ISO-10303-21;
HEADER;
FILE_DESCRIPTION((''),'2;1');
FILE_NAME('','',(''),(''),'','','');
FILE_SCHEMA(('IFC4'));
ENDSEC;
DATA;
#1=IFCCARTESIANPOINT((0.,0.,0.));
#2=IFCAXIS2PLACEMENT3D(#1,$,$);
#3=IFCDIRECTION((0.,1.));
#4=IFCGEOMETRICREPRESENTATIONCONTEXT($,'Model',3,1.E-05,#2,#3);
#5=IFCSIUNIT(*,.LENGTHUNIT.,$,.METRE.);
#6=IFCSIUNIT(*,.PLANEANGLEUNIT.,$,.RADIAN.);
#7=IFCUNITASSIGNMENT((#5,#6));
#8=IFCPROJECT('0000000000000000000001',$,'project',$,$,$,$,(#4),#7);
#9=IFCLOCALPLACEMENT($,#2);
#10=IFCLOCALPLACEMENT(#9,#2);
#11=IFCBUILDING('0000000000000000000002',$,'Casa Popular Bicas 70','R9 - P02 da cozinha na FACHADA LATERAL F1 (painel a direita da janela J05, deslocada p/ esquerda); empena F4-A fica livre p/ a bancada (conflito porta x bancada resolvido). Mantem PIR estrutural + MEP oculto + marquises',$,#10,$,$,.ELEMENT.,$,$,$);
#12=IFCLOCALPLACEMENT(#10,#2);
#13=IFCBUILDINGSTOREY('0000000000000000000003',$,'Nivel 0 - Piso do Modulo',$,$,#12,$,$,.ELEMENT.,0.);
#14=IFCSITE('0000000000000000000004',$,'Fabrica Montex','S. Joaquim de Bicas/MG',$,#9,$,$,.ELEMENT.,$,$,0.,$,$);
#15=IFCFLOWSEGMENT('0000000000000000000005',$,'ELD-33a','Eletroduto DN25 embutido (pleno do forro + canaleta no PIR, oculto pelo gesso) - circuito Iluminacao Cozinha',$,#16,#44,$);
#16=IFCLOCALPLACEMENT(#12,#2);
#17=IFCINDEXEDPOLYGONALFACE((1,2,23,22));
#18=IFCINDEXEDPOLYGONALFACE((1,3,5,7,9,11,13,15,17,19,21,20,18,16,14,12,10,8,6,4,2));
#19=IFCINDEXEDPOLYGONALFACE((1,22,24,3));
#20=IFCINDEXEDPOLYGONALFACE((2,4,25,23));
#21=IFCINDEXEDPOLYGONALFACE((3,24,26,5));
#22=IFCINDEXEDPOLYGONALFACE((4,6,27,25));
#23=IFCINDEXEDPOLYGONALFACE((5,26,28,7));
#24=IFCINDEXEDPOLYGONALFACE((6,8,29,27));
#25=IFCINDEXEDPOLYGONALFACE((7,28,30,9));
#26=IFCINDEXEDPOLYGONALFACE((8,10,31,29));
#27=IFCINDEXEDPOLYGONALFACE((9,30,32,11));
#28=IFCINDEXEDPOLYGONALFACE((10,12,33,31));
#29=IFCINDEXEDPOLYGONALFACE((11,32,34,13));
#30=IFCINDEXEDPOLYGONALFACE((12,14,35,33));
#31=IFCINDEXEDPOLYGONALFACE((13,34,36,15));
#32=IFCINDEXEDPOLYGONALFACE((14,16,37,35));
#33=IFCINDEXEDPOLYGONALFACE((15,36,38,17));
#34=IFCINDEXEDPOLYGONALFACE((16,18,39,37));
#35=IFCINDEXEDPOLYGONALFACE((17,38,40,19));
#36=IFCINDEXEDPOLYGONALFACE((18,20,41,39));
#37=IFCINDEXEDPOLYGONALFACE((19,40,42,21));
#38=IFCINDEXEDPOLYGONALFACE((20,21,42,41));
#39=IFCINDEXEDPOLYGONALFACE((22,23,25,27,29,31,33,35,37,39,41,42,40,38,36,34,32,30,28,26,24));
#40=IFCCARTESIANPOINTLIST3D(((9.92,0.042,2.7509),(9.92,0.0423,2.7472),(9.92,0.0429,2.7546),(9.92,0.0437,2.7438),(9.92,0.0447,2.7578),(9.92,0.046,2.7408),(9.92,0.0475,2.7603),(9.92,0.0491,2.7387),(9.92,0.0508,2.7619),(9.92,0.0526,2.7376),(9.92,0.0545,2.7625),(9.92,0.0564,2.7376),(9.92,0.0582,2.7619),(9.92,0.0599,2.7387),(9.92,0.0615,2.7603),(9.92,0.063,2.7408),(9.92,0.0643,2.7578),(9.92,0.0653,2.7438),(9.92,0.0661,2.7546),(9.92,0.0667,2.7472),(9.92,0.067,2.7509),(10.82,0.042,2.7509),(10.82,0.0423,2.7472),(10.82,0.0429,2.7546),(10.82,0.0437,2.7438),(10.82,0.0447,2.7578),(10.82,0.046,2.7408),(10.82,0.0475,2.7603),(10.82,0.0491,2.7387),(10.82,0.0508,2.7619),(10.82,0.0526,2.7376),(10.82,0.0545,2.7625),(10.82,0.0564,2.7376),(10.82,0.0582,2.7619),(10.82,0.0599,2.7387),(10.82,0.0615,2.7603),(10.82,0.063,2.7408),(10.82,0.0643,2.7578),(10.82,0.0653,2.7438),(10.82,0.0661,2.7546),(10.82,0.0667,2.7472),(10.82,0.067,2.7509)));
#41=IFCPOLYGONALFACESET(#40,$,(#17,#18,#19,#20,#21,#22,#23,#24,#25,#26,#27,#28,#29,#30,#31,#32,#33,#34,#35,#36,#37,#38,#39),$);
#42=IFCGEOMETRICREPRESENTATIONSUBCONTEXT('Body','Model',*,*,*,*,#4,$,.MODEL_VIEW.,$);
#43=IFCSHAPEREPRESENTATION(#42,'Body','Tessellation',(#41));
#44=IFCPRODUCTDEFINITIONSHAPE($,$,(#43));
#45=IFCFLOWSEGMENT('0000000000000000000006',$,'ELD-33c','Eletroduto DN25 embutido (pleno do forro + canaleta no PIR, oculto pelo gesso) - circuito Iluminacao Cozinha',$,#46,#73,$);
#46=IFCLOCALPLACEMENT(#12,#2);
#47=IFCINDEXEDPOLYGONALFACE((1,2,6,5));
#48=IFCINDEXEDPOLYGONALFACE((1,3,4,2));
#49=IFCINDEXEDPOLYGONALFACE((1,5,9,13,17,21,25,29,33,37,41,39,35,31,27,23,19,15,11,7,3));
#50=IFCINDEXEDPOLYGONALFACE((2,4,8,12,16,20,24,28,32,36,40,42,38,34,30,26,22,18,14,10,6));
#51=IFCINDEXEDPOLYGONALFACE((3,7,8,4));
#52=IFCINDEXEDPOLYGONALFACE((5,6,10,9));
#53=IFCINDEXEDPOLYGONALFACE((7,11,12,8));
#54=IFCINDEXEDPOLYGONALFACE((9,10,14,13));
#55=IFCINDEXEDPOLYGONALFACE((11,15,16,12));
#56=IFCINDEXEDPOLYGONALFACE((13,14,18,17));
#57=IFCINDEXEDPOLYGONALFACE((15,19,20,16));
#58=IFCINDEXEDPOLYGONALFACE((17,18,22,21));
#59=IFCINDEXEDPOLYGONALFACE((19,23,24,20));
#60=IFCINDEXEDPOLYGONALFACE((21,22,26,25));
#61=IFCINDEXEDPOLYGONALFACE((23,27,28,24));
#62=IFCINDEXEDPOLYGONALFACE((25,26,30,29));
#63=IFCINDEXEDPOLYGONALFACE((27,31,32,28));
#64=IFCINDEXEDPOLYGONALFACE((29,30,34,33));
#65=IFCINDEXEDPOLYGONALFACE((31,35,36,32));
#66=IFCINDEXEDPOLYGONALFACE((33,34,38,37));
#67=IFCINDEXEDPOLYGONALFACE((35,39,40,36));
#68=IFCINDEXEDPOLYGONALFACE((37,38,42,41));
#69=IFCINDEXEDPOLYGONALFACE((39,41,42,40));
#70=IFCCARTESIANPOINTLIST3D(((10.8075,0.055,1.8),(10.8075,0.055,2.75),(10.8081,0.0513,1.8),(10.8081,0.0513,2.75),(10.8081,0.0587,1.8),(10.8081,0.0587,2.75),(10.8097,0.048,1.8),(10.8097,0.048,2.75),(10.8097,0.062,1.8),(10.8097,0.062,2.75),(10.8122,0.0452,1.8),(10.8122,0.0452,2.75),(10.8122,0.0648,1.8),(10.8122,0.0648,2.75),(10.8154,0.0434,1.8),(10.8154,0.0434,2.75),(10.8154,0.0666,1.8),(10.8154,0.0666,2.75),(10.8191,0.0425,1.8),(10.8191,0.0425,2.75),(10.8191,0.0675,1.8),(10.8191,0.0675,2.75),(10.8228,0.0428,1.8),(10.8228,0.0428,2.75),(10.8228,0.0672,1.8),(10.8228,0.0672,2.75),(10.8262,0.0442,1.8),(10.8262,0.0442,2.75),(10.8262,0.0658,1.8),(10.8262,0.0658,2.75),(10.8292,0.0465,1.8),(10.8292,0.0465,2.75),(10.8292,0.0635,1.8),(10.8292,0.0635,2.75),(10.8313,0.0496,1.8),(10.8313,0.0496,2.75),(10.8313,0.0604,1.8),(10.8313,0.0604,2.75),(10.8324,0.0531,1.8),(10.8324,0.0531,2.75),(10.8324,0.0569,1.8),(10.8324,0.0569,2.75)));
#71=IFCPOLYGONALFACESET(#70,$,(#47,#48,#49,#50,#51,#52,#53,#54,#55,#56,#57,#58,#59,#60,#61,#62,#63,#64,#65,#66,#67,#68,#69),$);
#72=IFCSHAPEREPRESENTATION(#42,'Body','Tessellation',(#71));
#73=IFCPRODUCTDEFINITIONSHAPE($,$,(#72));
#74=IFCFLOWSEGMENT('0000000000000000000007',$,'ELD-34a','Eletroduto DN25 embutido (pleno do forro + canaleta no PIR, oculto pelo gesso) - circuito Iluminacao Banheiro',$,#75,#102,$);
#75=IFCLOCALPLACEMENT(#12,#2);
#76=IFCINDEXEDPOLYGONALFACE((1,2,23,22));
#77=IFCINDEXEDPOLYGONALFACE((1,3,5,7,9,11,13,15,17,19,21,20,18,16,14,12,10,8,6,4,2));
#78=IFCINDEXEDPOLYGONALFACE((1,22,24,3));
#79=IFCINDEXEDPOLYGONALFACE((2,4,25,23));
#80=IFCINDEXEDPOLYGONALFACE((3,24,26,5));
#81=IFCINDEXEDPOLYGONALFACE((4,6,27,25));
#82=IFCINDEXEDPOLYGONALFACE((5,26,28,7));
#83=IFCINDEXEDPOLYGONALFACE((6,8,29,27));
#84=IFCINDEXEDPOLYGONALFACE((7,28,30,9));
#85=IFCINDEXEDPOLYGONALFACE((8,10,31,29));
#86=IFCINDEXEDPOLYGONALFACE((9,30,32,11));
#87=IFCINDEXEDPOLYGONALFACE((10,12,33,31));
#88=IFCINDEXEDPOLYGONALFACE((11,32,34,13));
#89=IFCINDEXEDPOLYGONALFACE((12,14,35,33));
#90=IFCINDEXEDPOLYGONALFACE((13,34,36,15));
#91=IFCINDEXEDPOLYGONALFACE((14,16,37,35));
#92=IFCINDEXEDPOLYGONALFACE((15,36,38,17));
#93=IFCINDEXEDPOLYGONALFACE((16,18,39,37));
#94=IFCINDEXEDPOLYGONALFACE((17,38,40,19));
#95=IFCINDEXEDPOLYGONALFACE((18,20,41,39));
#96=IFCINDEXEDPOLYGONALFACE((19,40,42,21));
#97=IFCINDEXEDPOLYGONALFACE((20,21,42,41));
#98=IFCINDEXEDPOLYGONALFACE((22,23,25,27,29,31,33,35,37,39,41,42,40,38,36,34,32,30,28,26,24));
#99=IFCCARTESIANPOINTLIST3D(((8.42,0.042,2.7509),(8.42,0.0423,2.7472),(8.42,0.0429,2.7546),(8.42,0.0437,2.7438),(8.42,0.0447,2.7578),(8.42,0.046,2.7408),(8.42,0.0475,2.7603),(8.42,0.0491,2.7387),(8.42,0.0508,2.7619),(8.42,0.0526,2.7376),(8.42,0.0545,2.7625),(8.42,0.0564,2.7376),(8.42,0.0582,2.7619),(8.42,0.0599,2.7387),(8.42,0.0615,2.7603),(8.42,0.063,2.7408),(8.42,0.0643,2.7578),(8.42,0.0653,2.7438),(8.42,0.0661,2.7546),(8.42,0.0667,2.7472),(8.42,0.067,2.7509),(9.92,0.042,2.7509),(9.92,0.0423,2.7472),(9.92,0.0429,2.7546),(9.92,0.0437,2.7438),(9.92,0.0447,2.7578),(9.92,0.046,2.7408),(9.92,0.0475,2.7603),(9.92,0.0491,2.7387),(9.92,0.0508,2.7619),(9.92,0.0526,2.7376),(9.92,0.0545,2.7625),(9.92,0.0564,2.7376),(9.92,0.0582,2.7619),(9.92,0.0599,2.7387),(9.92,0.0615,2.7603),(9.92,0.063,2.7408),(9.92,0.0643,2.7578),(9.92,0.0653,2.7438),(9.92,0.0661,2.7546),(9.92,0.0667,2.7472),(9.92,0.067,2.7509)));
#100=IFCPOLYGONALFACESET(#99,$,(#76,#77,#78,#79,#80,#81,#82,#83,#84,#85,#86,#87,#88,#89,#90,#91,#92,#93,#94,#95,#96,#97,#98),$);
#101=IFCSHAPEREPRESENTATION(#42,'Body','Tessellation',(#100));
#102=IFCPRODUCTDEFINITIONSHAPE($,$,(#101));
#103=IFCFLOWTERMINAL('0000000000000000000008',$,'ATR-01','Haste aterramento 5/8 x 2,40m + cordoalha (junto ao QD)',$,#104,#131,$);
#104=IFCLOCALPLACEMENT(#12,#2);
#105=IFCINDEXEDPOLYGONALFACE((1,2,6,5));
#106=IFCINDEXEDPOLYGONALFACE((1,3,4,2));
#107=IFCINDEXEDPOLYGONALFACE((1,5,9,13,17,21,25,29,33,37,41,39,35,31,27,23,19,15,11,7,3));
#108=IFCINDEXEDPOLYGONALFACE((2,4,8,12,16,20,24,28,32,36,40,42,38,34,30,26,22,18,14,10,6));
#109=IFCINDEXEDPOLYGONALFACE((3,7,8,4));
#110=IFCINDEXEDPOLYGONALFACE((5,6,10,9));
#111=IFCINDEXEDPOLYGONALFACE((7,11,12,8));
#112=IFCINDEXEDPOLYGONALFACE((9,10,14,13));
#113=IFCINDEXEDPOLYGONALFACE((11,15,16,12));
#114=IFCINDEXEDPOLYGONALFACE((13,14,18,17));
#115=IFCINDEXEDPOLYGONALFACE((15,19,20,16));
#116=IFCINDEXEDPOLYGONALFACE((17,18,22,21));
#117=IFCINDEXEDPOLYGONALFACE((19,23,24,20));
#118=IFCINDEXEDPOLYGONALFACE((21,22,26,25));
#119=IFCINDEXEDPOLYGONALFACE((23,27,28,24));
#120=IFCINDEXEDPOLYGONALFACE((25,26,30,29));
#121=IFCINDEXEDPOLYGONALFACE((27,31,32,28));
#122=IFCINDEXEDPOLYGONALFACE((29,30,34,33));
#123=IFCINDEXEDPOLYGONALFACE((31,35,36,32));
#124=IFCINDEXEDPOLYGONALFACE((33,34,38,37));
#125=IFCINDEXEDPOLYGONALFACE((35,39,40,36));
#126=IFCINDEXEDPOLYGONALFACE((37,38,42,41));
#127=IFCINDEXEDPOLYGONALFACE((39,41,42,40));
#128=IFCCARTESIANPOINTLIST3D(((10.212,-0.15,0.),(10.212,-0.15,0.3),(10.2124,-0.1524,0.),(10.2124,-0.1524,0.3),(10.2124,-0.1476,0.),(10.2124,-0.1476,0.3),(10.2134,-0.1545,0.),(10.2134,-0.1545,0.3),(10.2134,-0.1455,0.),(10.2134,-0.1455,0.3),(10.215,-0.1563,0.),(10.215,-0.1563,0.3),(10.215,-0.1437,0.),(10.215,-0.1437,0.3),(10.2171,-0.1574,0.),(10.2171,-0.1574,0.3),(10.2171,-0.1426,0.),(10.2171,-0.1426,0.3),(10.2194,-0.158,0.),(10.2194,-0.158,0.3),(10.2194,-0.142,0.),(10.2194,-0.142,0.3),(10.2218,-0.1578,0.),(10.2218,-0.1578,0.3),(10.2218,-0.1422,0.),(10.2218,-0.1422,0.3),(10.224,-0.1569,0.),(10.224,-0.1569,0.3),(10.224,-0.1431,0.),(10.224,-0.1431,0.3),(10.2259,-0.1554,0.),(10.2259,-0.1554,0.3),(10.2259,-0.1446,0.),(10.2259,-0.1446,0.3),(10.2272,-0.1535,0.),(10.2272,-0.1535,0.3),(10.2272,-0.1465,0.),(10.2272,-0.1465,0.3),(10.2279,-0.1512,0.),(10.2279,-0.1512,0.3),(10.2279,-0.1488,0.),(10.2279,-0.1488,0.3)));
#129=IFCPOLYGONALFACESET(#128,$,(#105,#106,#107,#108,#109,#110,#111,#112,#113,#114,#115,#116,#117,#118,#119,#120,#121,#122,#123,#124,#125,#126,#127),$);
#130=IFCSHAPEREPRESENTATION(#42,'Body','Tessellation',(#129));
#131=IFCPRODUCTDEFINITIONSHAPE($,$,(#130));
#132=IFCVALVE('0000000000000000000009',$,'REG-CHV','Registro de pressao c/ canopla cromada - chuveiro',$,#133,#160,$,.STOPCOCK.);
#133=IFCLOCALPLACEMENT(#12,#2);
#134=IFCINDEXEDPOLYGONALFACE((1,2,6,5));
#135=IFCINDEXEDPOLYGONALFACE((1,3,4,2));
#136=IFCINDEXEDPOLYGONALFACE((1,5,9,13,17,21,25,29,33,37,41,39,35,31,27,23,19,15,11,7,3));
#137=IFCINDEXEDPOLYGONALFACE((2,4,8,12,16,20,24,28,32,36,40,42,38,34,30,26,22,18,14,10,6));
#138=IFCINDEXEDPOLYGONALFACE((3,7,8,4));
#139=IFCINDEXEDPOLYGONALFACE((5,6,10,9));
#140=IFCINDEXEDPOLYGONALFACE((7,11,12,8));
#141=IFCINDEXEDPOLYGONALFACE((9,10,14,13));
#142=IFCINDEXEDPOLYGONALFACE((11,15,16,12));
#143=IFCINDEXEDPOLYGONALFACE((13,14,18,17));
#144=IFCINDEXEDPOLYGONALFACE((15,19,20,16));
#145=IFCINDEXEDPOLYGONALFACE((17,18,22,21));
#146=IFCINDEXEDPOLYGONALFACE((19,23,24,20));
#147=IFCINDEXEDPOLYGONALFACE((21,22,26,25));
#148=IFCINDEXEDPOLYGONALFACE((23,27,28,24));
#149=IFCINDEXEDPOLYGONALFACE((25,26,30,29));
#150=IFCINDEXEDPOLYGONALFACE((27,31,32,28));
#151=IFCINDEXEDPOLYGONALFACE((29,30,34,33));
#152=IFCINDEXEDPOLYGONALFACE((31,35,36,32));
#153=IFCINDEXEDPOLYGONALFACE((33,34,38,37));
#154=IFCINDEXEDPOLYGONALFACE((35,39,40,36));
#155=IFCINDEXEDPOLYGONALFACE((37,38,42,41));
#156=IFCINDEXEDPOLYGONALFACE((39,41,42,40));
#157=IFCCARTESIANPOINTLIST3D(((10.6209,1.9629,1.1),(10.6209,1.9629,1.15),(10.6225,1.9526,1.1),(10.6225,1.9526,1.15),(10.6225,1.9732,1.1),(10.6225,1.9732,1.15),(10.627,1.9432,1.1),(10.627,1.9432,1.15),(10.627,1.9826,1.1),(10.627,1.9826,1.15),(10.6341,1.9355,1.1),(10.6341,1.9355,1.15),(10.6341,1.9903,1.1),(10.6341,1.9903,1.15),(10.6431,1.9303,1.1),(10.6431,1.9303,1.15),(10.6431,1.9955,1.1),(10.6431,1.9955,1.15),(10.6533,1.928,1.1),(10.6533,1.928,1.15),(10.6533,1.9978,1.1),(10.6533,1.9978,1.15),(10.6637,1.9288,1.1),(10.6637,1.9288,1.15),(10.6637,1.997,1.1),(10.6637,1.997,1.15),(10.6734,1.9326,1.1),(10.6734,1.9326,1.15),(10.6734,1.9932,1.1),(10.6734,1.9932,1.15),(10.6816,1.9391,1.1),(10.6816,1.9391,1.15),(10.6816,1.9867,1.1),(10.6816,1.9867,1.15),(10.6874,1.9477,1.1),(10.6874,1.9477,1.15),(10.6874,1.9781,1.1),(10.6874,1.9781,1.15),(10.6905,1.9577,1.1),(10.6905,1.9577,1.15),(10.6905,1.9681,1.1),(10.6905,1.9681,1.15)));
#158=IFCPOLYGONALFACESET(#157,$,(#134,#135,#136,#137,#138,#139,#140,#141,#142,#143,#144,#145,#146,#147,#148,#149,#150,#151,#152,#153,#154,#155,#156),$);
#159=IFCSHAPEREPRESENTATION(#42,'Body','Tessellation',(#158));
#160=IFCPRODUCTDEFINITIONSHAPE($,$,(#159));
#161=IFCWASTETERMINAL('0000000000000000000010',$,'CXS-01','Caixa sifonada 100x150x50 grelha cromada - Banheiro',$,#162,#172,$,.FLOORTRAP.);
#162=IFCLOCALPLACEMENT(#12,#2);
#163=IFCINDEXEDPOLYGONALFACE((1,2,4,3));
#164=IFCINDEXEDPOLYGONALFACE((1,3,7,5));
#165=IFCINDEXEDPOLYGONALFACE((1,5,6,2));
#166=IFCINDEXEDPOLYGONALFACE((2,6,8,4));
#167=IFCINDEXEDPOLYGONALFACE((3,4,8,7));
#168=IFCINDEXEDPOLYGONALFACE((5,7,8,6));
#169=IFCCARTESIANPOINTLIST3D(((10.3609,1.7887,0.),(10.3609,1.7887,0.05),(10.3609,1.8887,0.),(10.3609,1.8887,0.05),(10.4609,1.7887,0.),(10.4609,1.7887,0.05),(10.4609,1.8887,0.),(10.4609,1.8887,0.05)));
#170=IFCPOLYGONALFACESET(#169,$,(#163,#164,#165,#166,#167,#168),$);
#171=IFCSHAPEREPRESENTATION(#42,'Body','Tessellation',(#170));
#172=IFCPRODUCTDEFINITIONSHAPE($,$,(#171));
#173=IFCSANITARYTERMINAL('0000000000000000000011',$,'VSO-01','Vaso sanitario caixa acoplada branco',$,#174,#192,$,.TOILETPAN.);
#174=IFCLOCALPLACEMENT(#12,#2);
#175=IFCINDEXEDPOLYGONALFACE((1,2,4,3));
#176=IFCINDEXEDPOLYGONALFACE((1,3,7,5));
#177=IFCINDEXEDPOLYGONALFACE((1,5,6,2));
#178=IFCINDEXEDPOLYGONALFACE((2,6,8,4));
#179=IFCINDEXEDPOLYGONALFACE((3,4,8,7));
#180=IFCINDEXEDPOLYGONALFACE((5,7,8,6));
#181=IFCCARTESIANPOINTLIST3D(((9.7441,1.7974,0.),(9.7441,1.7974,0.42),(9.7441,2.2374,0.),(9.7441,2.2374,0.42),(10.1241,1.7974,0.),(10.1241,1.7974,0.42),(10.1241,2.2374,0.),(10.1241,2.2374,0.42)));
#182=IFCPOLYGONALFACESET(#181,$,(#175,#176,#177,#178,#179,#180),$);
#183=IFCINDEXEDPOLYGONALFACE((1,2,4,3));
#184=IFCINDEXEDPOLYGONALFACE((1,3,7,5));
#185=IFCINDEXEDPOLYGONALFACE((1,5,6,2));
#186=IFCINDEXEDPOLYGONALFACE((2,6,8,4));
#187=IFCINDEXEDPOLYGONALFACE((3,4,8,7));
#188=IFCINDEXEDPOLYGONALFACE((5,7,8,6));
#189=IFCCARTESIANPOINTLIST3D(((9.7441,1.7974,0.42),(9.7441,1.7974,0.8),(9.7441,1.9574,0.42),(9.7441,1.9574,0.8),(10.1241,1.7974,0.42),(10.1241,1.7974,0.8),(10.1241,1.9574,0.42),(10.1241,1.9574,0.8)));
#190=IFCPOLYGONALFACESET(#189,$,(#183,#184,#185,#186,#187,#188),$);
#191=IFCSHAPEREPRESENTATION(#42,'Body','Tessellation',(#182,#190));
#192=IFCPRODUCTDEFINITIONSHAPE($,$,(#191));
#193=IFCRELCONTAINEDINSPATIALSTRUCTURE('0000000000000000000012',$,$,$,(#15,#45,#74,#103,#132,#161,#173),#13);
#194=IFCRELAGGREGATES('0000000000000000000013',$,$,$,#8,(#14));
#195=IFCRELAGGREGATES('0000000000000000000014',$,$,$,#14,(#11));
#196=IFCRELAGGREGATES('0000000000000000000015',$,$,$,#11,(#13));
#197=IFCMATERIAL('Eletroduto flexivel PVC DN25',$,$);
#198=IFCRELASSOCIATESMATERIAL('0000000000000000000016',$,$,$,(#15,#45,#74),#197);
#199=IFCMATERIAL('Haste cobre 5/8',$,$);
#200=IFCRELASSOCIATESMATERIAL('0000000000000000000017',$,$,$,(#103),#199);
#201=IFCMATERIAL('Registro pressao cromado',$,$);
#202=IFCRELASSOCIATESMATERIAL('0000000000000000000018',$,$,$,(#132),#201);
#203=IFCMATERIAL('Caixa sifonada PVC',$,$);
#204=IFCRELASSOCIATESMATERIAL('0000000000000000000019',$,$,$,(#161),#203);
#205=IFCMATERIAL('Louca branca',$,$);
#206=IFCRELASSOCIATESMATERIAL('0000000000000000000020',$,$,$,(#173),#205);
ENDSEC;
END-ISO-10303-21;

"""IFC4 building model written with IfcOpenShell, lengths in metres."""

from ifc_helpers import new_model, si_unit, direction, frame, frame_2d, origin, origin_2d, place, context, subcontext, project, spatial, rectangle, circle, extrude, material, element, save


model = new_model("IFC4")

# Units and contexts
model_context = context("Model", 3, precision=1e-05, world=origin(), true_north=direction((0.0, 1.0)))
body_context = subcontext(model_context, "Body", "Model", "MODEL_VIEW")
ifc_project = project(units=[si_unit("LENGTHUNIT", "METRE"), si_unit("PLANEANGLEUNIT", "RADIAN")], contexts=[model_context])

# Site, building, storey
site_placement = place(None, origin())
site = spatial("IfcSite", under=ifc_project, at=site_placement, Name="Fabrica Montex", Description="S. Joaquim de Bicas/MG", CompositionType="ELEMENT", RefElevation=0.0)
building_placement = place(site_placement, origin())
building = spatial("IfcBuilding", under=site, at=building_placement, Name="Casa Popular Bicas 70", Description="R9 - P02 da cozinha na FACHADA LATERAL F1 (painel a direita da janela J05, deslocada p/ esquerda); empena F4-A fica livre p/ a bancada (conflito porta x bancada resolvido). Mantem PIR estrutural + MEP oculto + marquises", CompositionType="ELEMENT")
storey_placement = place(building_placement, origin())
storey = spatial("IfcBuildingStorey", under=building, at=storey_placement, Name="Nivel 0 - Piso do Modulo", CompositionType="ELEMENT", Elevation=0.0)

# Shared definitions
ifc_material_1 = material(Name="Eletroduto flexivel PVC DN25")

# Flow segments
flow_segment_1_placement = place(None, frame((9.92, 0.0545, 2.75), z_axis=(1.0, 0.0, 0.0), x_axis=(0.0, 0.0, 1.0)))
element("IfcFlowSegment", 1, at=flow_segment_1_placement, inside=storey, material=ifc_material_1, Name="ELD-33a", Description="Eletroduto DN25 embutido (pleno do forro + canaleta no PIR, oculto pelo gesso) - circuito Iluminacao Cozinha", context=body_context, shape_type="SweptSolid", body=[
    extrude(circle(Radius=0.0125, at=origin_2d()), origin(), (0.0, 0.0, 1.0), 0.9),
])
flow_segment_2_placement = place(None, frame((10.82, 0.055, 2.75), z_axis=(0.0, 0.0, -1.0), x_axis=(-1.0, 0.0, 0.0)))
element("IfcFlowSegment", 2, at=flow_segment_2_placement, inside=storey, material=ifc_material_1, Name="ELD-33c", Description="Eletroduto DN25 embutido (pleno do forro + canaleta no PIR, oculto pelo gesso) - circuito Iluminacao Cozinha", context=body_context, shape_type="SweptSolid", body=[
    extrude(circle(Radius=0.0125, at=origin_2d()), origin(), (0.0, 0.0, 1.0), 0.95),
])
flow_segment_3_placement = place(None, frame((9.92, 0.0545, 2.75), z_axis=(-1.0, 0.0, 0.0), x_axis=(0.0, 0.0, 1.0)))
element("IfcFlowSegment", 3, at=flow_segment_3_placement, inside=storey, material=ifc_material_1, Name="ELD-34a", Description="Eletroduto DN25 embutido (pleno do forro + canaleta no PIR, oculto pelo gesso) - circuito Iluminacao Banheiro", context=body_context, shape_type="SweptSolid", body=[
    extrude(circle(Radius=0.0125, at=origin_2d()), origin(), (0.0, 0.0, 1.0), 1.5),
])

# Flow terminal
ifc_material_2 = material(Name="Haste cobre 5/8")
flow_terminal_placement = place(None, frame((10.22, -0.15, 0.0), z_axis=(0.0, 0.0, 1.0), x_axis=(-1.0, 0.0, 0.0)))
element("IfcFlowTerminal", 4, at=flow_terminal_placement, inside=storey, material=ifc_material_2, Name="ATR-01", Description="Haste aterramento 5/8 x 2,40m + cordoalha (junto ao QD)", context=body_context, shape_type="SweptSolid", body=[
    extrude(circle(Radius=0.008, at=origin_2d()), origin(), (0.0, 0.0, 1.0), 0.3),
])

# Valve
ifc_material_3 = material(Name="Registro pressao cromado")
valve_placement = place(None, frame((10.6559, 1.9629, 1.1), z_axis=(0.0, 0.0, 1.0), x_axis=(-1.0, 0.0, 0.0)))
element("IfcValve", 5, at=valve_placement, inside=storey, material=ifc_material_3, Name="REG-CHV", Description="Registro de pressao c/ canopla cromada - chuveiro", PredefinedType="STOPCOCK", context=body_context, shape_type="SweptSolid", body=[
    extrude(circle(Radius=0.035, at=origin_2d()), origin(), (0.0, 0.0, 1.0), 0.05),
])

# Waste terminal
ifc_material_4 = material(Name="Caixa sifonada PVC")
waste_terminal_placement = place(None, frame((10.4609, 1.8887, 0.0), z_axis=(0.0, 0.0, 1.0), x_axis=(-1.0, 0.0, 0.0)))
element("IfcWasteTerminal", 6, at=waste_terminal_placement, inside=storey, material=ifc_material_4, Name="CXS-01", Description="Caixa sifonada 100x150x50 grelha cromada - Banheiro", PredefinedType="FLOORTRAP", context=body_context, shape_type="SweptSolid", body=[
    extrude(rectangle(XDim=0.1, YDim=0.1, at=frame_2d((0.05, 0.05))), origin(), (0.0, 0.0, 1.0), 0.05),
])

# Sanitary terminal
ifc_material_5 = material(Name="Louca branca")
sanitary_terminal_1_placement = place(None, frame((10.1241, 2.2374, 0.0), z_axis=(0.0, 0.0, 1.0), x_axis=(-1.0, 0.0, 0.0)))
element("IfcSanitaryTerminal", 7, at=sanitary_terminal_1_placement, inside=storey, material=ifc_material_5, Name="VSO-01", Description="Vaso sanitario caixa acoplada branco", PredefinedType="TOILETPAN", context=body_context, shape_type="SweptSolid", body=[
    extrude(rectangle(XDim=0.38, YDim=0.44, at=frame_2d((0.19, 0.22))), origin(), (0.0, 0.0, 1.0), 0.42),
    extrude(rectangle(XDim=0.38, YDim=0.16, at=frame_2d((0.19, 0.36))), frame((0.0, 0.0, 0.42)), (0.0, 0.0, 1.0), 0.38),
])

save(model, "model.ifc")
